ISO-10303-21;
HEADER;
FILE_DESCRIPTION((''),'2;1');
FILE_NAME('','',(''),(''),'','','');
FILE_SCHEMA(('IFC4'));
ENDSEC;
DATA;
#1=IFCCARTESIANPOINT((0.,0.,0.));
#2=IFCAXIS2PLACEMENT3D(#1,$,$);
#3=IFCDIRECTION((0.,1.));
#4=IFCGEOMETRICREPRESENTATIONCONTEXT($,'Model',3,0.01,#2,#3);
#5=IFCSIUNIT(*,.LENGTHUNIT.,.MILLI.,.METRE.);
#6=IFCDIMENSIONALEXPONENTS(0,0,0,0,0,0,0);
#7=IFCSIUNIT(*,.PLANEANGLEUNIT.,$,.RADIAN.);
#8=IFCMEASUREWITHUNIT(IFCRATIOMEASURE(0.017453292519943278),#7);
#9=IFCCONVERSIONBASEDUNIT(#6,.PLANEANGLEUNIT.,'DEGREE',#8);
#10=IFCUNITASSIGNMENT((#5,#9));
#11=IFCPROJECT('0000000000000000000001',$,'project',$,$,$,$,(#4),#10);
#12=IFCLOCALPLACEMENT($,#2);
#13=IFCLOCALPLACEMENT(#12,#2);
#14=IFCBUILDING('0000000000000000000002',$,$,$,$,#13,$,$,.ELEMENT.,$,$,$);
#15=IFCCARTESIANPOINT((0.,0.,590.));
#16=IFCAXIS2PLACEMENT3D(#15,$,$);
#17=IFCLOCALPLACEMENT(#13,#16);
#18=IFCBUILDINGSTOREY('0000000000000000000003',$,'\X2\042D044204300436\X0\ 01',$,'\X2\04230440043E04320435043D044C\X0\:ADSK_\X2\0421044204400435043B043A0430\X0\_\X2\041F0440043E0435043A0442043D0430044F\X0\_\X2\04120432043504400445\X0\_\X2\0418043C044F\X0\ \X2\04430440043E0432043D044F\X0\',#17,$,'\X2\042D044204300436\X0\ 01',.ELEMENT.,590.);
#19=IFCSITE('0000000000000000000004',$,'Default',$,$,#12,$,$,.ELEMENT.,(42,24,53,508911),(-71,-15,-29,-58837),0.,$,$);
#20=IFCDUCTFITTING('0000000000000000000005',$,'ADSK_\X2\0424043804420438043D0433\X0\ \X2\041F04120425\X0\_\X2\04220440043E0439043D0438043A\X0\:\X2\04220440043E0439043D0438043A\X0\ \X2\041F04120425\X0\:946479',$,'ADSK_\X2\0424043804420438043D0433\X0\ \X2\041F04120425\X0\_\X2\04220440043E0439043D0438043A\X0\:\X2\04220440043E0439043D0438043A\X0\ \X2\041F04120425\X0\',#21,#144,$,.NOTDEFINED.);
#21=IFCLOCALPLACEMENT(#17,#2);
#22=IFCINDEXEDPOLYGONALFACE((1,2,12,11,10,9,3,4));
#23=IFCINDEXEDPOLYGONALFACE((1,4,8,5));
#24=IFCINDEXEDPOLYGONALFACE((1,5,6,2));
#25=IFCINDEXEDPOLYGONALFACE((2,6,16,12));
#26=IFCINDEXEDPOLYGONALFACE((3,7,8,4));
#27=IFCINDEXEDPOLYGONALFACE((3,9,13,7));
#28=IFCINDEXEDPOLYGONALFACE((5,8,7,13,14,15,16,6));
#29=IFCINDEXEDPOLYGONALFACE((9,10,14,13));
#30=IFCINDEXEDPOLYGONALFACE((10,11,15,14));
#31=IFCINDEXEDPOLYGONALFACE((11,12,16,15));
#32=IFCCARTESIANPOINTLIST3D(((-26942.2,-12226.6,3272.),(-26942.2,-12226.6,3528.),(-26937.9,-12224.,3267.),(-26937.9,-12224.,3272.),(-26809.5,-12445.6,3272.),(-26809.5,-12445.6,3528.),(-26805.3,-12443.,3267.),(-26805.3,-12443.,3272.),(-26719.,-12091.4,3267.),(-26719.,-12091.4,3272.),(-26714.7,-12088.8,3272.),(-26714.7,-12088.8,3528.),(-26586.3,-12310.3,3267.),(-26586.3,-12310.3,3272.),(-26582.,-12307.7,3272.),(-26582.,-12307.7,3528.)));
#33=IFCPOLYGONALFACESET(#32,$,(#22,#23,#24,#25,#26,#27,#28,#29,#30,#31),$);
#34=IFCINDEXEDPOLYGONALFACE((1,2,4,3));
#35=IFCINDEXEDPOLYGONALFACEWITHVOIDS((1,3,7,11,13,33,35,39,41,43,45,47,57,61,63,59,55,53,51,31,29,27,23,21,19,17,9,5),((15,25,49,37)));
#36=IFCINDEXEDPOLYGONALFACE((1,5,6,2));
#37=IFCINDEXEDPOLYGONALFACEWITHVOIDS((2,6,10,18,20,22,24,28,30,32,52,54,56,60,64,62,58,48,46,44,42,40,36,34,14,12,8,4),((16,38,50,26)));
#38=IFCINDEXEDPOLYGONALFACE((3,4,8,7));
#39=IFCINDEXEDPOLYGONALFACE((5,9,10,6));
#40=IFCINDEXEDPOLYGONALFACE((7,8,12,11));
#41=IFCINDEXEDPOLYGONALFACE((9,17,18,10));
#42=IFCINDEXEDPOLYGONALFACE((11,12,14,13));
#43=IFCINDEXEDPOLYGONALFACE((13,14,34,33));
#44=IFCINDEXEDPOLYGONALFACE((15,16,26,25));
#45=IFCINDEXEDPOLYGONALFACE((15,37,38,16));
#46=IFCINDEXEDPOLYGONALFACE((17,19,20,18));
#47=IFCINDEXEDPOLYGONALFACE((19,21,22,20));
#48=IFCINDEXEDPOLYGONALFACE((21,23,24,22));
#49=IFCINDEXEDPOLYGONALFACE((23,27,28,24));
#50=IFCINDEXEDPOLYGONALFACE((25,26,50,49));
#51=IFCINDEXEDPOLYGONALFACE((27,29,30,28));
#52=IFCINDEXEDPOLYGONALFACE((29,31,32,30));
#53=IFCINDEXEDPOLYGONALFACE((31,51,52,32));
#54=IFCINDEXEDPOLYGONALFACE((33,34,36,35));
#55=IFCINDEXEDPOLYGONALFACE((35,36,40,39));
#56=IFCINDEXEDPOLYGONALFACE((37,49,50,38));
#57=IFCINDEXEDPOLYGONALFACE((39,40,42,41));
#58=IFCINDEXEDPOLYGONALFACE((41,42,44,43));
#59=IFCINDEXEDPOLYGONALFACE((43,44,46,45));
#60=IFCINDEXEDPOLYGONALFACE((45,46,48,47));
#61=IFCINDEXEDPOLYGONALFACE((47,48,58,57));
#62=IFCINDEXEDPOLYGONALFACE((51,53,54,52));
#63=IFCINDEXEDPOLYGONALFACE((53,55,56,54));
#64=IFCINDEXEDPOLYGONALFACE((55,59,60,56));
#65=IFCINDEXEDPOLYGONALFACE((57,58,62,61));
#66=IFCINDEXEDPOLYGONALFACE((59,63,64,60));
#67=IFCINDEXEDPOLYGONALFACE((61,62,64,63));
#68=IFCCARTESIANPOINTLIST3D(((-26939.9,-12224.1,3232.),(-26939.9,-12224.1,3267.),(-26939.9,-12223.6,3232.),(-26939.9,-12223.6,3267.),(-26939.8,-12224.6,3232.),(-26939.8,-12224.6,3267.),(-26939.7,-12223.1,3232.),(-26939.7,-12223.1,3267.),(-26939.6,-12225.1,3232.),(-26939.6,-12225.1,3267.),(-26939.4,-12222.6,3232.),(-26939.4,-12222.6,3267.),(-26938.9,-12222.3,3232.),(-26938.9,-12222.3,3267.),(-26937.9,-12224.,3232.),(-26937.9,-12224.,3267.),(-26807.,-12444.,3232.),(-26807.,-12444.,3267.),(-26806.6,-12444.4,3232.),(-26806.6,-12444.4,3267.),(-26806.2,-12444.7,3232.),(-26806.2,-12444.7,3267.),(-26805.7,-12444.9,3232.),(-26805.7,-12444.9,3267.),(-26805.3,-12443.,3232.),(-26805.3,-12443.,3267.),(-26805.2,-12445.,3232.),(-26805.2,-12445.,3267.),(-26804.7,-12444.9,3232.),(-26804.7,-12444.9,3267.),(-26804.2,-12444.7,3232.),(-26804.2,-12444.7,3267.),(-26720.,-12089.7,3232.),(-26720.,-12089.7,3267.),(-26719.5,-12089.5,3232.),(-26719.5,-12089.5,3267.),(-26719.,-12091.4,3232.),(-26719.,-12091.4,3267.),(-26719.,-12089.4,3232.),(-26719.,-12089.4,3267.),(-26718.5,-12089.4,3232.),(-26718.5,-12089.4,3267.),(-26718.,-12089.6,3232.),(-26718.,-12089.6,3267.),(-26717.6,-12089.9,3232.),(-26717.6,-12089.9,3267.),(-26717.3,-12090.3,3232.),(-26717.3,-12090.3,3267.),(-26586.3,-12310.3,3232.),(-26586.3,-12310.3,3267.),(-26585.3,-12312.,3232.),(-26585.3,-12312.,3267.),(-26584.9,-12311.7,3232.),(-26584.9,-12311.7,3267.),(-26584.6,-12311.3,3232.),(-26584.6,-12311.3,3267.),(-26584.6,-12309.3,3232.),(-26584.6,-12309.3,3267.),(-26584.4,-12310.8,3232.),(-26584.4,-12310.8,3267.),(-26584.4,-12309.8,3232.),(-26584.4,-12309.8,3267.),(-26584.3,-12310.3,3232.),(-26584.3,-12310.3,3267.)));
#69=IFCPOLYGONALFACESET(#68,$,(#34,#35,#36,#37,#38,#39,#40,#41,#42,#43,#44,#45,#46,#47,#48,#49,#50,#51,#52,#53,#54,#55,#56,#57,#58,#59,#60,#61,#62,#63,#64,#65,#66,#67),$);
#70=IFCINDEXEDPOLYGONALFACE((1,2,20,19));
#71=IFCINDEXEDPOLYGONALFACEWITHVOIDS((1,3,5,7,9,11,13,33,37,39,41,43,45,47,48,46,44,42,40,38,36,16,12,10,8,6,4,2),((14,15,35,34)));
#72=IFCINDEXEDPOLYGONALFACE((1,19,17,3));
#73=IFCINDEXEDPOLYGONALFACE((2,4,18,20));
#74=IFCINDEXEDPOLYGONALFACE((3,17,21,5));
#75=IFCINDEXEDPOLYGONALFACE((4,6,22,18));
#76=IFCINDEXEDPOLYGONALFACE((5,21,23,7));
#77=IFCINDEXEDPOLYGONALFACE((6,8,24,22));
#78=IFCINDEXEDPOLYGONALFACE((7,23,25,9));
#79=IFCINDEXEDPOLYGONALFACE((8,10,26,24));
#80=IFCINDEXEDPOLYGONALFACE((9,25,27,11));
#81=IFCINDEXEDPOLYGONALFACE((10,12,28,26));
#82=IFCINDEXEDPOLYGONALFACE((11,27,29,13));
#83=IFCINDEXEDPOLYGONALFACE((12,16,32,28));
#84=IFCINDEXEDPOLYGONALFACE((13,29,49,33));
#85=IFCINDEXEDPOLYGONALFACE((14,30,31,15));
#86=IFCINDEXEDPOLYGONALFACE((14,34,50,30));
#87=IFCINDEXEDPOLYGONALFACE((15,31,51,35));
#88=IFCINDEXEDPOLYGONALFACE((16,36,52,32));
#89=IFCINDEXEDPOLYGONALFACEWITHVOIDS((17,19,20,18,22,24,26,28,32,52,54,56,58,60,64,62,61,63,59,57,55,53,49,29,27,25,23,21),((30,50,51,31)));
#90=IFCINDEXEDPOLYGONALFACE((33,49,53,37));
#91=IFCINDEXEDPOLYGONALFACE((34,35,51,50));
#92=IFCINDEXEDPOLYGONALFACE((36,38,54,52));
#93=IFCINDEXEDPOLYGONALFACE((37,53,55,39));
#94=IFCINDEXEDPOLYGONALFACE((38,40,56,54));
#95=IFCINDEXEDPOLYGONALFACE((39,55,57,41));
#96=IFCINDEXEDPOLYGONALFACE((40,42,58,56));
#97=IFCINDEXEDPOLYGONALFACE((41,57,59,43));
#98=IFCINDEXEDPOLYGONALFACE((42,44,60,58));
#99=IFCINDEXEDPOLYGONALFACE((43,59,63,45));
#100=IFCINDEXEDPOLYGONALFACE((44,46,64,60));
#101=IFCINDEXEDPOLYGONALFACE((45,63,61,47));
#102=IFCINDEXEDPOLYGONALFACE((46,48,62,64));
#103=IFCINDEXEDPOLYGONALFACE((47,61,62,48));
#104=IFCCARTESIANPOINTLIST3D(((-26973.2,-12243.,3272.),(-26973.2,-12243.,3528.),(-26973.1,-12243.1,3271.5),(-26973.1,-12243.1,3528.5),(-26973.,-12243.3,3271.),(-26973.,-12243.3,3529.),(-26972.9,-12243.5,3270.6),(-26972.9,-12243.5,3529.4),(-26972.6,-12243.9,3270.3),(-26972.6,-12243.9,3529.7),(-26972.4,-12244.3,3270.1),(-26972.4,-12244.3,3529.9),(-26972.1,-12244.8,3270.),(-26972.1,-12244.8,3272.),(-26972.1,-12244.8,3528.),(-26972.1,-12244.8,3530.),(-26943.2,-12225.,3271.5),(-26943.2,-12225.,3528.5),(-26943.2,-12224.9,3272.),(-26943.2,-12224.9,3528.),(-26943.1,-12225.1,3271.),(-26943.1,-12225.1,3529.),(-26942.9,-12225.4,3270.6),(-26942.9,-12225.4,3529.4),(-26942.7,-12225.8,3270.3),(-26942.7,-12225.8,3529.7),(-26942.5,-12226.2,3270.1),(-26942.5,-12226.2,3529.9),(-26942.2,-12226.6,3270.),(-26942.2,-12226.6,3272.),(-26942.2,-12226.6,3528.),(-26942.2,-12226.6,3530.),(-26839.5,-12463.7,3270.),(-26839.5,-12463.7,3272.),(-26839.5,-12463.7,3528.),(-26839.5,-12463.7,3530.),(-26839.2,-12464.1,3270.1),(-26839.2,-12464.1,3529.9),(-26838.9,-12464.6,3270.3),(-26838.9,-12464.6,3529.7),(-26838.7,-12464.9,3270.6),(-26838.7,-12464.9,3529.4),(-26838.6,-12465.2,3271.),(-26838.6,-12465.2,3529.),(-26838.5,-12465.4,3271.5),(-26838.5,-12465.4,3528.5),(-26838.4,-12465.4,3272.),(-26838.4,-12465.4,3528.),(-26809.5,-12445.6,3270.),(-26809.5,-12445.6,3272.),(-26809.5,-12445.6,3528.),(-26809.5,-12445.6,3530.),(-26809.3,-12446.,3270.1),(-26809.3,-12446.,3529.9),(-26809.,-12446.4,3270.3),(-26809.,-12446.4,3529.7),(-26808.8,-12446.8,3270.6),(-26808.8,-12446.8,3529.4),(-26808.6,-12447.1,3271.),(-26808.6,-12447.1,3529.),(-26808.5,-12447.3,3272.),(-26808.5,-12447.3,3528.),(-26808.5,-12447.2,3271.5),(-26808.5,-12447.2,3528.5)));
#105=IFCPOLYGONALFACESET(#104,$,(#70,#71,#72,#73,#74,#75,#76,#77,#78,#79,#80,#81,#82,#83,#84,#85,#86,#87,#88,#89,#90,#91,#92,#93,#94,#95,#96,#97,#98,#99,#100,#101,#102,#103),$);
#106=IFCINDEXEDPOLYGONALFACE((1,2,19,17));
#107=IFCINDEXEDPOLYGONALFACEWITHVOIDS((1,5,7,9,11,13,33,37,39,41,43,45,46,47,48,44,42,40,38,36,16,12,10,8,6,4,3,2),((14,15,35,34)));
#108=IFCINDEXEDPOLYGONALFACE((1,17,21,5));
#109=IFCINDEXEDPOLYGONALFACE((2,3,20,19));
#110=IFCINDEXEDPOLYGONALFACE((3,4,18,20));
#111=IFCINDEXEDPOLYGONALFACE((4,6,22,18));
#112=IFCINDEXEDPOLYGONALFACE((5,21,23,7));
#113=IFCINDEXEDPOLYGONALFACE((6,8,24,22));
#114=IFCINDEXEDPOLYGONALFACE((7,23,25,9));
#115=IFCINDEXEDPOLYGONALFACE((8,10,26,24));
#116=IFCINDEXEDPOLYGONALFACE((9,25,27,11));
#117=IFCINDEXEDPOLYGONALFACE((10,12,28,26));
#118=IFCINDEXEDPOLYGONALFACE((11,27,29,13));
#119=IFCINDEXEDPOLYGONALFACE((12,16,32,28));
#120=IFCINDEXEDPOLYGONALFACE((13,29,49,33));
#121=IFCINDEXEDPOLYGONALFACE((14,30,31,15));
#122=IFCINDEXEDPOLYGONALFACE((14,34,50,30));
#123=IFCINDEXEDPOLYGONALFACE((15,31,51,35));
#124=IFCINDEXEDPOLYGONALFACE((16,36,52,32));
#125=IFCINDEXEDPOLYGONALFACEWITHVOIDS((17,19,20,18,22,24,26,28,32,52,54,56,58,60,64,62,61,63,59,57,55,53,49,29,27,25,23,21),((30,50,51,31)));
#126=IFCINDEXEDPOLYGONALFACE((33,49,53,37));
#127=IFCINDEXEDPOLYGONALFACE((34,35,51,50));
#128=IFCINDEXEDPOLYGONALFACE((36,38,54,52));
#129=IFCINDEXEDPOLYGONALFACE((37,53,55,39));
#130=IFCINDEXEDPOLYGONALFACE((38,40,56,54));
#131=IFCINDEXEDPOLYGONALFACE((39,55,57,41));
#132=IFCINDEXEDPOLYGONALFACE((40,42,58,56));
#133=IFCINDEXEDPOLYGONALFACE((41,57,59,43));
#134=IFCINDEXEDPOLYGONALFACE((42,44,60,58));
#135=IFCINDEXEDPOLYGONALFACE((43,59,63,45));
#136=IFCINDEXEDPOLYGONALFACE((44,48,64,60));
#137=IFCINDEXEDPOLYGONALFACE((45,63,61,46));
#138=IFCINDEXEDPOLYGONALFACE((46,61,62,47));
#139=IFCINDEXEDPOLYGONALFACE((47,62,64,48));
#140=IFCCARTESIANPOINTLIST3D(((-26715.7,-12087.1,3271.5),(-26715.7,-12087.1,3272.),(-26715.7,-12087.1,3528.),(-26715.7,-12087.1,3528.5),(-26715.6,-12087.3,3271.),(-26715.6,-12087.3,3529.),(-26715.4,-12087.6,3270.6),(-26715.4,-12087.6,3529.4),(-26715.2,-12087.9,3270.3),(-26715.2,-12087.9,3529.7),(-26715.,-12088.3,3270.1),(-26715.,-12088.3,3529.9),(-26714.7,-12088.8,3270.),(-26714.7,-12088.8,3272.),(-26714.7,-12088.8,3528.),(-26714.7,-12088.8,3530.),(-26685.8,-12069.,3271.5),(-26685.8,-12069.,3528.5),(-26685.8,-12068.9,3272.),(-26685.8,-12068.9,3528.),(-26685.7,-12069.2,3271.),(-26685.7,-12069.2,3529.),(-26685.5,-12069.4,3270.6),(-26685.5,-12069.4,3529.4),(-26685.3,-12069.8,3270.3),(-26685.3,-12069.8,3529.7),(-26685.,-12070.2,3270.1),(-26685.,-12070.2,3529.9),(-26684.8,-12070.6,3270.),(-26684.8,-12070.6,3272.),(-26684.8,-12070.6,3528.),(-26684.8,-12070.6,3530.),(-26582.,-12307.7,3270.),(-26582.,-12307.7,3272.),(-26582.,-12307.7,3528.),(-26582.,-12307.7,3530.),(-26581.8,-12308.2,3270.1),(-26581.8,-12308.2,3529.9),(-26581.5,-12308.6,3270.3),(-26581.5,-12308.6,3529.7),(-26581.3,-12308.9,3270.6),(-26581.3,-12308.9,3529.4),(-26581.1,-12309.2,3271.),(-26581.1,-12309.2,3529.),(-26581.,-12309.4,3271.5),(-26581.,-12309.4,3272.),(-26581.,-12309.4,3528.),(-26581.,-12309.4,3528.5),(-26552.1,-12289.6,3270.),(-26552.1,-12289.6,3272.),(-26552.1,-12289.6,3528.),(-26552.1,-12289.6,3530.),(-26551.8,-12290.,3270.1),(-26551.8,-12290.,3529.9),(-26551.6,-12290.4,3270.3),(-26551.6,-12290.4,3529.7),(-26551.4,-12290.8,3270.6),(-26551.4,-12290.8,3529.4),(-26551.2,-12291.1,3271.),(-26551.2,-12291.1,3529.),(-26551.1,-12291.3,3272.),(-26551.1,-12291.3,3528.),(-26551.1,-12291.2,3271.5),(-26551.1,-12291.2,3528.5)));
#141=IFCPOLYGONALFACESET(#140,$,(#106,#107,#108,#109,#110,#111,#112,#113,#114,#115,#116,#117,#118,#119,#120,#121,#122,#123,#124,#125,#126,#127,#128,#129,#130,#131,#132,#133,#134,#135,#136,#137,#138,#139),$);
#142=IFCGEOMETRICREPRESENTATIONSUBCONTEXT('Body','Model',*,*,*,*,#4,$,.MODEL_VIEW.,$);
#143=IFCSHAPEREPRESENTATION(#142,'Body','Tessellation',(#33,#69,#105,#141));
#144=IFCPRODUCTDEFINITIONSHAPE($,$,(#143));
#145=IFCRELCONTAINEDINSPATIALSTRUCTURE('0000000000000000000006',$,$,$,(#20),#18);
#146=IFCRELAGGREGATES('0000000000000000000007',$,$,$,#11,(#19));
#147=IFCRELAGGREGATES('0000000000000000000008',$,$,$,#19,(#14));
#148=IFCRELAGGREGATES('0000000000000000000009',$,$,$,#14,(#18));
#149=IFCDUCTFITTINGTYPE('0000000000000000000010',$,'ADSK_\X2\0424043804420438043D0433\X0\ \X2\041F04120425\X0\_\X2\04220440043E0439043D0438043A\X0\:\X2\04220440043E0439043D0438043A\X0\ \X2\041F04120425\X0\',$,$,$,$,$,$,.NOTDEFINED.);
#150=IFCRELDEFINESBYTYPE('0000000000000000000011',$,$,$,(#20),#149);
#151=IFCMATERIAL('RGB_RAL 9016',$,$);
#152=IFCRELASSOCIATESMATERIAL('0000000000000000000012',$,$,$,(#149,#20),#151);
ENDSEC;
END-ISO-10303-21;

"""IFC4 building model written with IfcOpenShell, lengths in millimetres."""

from ifc_helpers import new_model, entity, si_unit, converted_unit, direction, frame, frame_2d, origin, place, context, subcontext, project, spatial, polyline, circle_curve, parameter, trimmed, segment, composite_curve, outline, extrude, source, transform, mapped, material, type_object, type_shapes, element, save


model = new_model("IFC4")

# Units and contexts
model_context = context("Model", 3, precision=0.01, world=origin(), true_north=direction((0.0, 1.0)))
body_context = subcontext(model_context, "Body", "Model", "MODEL_VIEW")
ifc_project = project(units=[si_unit("LENGTHUNIT", "METRE", prefix="MILLI"), converted_unit("PLANEANGLEUNIT", "DEGREE", entity("IfcRatioMeasure", 0.017453292519943278), si_unit("PLANEANGLEUNIT", "RADIAN"), dimensions=[0, 0, 0, 0, 0, 0, 0])], contexts=[model_context])

# Site, building, storey
site_placement = place(None, origin())
site = spatial("IfcSite", under=ifc_project, at=site_placement, Name="Default", CompositionType="ELEMENT", RefLatitude=(42, 24, 53, 508911), RefLongitude=(-71, -15, -29, -58837), RefElevation=0.0)
building_placement = place(site_placement, origin())
building = spatial("IfcBuilding", under=site, at=building_placement, CompositionType="ELEMENT")
storey_placement = place(building_placement, frame((0.0, 0.0, 590.0)))
storey = spatial("IfcBuildingStorey", under=building, at=storey_placement, Name="Этаж 01", ObjectType="Уровень:ADSK_Стрелка_Проектная_Вверх_Имя уровня", LongName="Этаж 01", CompositionType="ELEMENT", Elevation=590.0)

# Duct fitting
ifc_material_1 = material(Name="RGB_RAL 9016")
duct_fitting_type_1 = type_object("IfcDuctFittingType", Name="ADSK_Фитинг ПВХ_Тройник:Тройник ПВХ", PredefinedType="NOTDEFINED", material=ifc_material_1)
shared_shape_1 = source(origin(), body_context, "Body", "SweptSolid", [
    extrude(outline(polyline([(-133.0, -193.2), (133.0, -193.2), (133.0, 62.7), (128.0, 62.7), (128.0, 67.8), (-128.0, 67.8), (-128.0, 62.7), (-133.0, 62.7), (-133.0, -193.2)])), frame((0.0, -65.3, -128.0), z_axis=(0.0, 0.0, 1.0), x_axis=(-1.0, 0.0, 0.0)), (0.0, 0.0, 1.0), 256.0),
    extrude(outline(composite_curve([segment(trimmed(circle_curve(frame_2d((128.0, -128.0), x_axis=(1.0, 0.0)), 2.0), [parameter(270.0)], [parameter(0.0)], True, "PARAMETER"), True, "CONTINUOUS"), segment(polyline([(130.0, -128.0), (130.0, 128.0)]), True, "CONTINUOUS"), segment(trimmed(circle_curve(frame_2d((128.0, 128.0), x_axis=(1.0, 0.0)), 2.0), [parameter(0.0)], [parameter(90.0)], True, "PARAMETER"), True, "CONTINUOUS"), segment(polyline([(128.0, 130.0), (-128.0, 130.0)]), True, "CONTINUOUS"), segment(trimmed(circle_curve(frame_2d((-128.0, 128.0), x_axis=(1.0, 0.0)), 2.0), [parameter(90.0)], [parameter(180.0)], True, "PARAMETER"), True, "CONTINUOUS"), segment(polyline([(-130.0, 128.0), (-130.0, -128.0)]), True, "CONTINUOUS"), segment(trimmed(circle_curve(frame_2d((-128.0, -128.0), x_axis=(1.0, 0.0)), 2.0), [parameter(180.0)], [parameter(270.0)], True, "PARAMETER"), True, "CONTINUOUS"), segment(polyline([(-128.0, -130.0), (128.0, -130.0)]), True, "CONTINUOUS")], self_intersect=False), holes=[polyline([(128.0, -128.0), (-128.0, -128.0), (-128.0, 128.0), (128.0, 128.0), (128.0, -128.0)])]), frame((0.0, -168.0, 0.0), z_axis=(0.0, 1.0, 0.0), x_axis=(1.0, 0.0, 0.0)), (0.0, 0.0, 1.0), 35.0),
    extrude(outline(composite_curve([segment(trimmed(circle_curve(frame_2d((-128.0, 128.0), x_axis=(1.0, 0.0)), 2.0), [parameter(90.0)], [parameter(180.0)], True, "PARAMETER"), True, "CONTINUOUS"), segment(polyline([(-130.0, 128.0), (-130.0, -128.0)]), True, "CONTINUOUS"), segment(trimmed(circle_curve(frame_2d((-128.0, -128.0), x_axis=(1.0, 0.0)), 2.0), [parameter(180.0)], [parameter(270.0)], True, "PARAMETER"), True, "CONTINUOUS"), segment(polyline([(-128.0, -130.0), (128.0, -130.0)]), True, "CONTINUOUS"), segment(trimmed(circle_curve(frame_2d((128.0, -128.0), x_axis=(1.0, 0.0)), 2.0), [parameter(270.0)], [parameter(0.0)], True, "PARAMETER"), True, "CONTINUOUS"), segment(polyline([(130.0, -128.0), (130.0, 128.0)]), True, "CONTINUOUS"), segment(trimmed(circle_curve(frame_2d((128.0, 128.0), x_axis=(1.0, 0.0)), 2.0), [parameter(0.0)], [parameter(90.0)], True, "PARAMETER"), True, "CONTINUOUS"), segment(polyline([(128.0, 130.0), (-128.0, 130.0)]), True, "CONTINUOUS")], self_intersect=False), holes=[polyline([(-128.0, 128.0), (128.0, 128.0), (128.0, -128.0), (-128.0, -128.0), (-128.0, 128.0)])]), frame((133.0, 0.0, 0.0), z_axis=(1.0, 0.0, 0.0), x_axis=(0.0, 1.0, 0.0)), (0.0, 0.0, 1.0), 35.0),
    extrude(outline(composite_curve([segment(trimmed(circle_curve(frame_2d((-128.0, 128.0), x_axis=(1.0, 0.0)), 2.0), [parameter(90.0)], [parameter(180.0)], True, "PARAMETER"), True, "CONTINUOUS"), segment(polyline([(-130.0, 128.0), (-130.0, -128.0)]), True, "CONTINUOUS"), segment(trimmed(circle_curve(frame_2d((-128.0, -128.0), x_axis=(1.0, 0.0)), 2.0), [parameter(180.0)], [parameter(270.0)], True, "PARAMETER"), True, "CONTINUOUS"), segment(polyline([(-128.0, -130.0), (128.0, -130.0)]), True, "CONTINUOUS"), segment(trimmed(circle_curve(frame_2d((128.0, -128.0), x_axis=(1.0, 0.0)), 2.0), [parameter(270.0)], [parameter(0.0)], True, "PARAMETER"), True, "CONTINUOUS"), segment(polyline([(130.0, -128.0), (130.0, 128.0)]), True, "CONTINUOUS"), segment(trimmed(circle_curve(frame_2d((128.0, 128.0), x_axis=(1.0, 0.0)), 2.0), [parameter(0.0)], [parameter(90.0)], True, "PARAMETER"), True, "CONTINUOUS"), segment(polyline([(128.0, 130.0), (-128.0, 130.0)]), True, "CONTINUOUS")], self_intersect=False), holes=[polyline([(-128.0, 128.0), (128.0, 128.0), (128.0, -128.0), (-128.0, -128.0), (-128.0, 128.0)])]), frame((-168.0, 0.0, 0.0), z_axis=(1.0, 0.0, 0.0), x_axis=(0.0, 1.0, 0.0)), (0.0, 0.0, 1.0), 35.0),
])
type_shapes(duct_fitting_type_1, [shared_shape_1])
duct_fitting_1_placement = place(storey_placement, frame((-26762.1, -12267.2, 3400.0), z_axis=(-0.518188, 0.855267, 0.0), x_axis=(-0.855267, -0.518188, 0.0)))
element("IfcDuctFitting", 1, at=duct_fitting_1_placement, inside=storey, type_object=duct_fitting_type_1, material=ifc_material_1, Name="ADSK_Фитинг ПВХ_Тройник:Тройник ПВХ:946479", ObjectType="ADSK_Фитинг ПВХ_Тройник:Тройник ПВХ", PredefinedType="NOTDEFINED", context=body_context, shape_type="MappedRepresentation", body=[
    mapped(shared_shape_1, transform((0.0, 0.0, 0.0), scale=1.0)),
])

save(model, "model.ifc")
